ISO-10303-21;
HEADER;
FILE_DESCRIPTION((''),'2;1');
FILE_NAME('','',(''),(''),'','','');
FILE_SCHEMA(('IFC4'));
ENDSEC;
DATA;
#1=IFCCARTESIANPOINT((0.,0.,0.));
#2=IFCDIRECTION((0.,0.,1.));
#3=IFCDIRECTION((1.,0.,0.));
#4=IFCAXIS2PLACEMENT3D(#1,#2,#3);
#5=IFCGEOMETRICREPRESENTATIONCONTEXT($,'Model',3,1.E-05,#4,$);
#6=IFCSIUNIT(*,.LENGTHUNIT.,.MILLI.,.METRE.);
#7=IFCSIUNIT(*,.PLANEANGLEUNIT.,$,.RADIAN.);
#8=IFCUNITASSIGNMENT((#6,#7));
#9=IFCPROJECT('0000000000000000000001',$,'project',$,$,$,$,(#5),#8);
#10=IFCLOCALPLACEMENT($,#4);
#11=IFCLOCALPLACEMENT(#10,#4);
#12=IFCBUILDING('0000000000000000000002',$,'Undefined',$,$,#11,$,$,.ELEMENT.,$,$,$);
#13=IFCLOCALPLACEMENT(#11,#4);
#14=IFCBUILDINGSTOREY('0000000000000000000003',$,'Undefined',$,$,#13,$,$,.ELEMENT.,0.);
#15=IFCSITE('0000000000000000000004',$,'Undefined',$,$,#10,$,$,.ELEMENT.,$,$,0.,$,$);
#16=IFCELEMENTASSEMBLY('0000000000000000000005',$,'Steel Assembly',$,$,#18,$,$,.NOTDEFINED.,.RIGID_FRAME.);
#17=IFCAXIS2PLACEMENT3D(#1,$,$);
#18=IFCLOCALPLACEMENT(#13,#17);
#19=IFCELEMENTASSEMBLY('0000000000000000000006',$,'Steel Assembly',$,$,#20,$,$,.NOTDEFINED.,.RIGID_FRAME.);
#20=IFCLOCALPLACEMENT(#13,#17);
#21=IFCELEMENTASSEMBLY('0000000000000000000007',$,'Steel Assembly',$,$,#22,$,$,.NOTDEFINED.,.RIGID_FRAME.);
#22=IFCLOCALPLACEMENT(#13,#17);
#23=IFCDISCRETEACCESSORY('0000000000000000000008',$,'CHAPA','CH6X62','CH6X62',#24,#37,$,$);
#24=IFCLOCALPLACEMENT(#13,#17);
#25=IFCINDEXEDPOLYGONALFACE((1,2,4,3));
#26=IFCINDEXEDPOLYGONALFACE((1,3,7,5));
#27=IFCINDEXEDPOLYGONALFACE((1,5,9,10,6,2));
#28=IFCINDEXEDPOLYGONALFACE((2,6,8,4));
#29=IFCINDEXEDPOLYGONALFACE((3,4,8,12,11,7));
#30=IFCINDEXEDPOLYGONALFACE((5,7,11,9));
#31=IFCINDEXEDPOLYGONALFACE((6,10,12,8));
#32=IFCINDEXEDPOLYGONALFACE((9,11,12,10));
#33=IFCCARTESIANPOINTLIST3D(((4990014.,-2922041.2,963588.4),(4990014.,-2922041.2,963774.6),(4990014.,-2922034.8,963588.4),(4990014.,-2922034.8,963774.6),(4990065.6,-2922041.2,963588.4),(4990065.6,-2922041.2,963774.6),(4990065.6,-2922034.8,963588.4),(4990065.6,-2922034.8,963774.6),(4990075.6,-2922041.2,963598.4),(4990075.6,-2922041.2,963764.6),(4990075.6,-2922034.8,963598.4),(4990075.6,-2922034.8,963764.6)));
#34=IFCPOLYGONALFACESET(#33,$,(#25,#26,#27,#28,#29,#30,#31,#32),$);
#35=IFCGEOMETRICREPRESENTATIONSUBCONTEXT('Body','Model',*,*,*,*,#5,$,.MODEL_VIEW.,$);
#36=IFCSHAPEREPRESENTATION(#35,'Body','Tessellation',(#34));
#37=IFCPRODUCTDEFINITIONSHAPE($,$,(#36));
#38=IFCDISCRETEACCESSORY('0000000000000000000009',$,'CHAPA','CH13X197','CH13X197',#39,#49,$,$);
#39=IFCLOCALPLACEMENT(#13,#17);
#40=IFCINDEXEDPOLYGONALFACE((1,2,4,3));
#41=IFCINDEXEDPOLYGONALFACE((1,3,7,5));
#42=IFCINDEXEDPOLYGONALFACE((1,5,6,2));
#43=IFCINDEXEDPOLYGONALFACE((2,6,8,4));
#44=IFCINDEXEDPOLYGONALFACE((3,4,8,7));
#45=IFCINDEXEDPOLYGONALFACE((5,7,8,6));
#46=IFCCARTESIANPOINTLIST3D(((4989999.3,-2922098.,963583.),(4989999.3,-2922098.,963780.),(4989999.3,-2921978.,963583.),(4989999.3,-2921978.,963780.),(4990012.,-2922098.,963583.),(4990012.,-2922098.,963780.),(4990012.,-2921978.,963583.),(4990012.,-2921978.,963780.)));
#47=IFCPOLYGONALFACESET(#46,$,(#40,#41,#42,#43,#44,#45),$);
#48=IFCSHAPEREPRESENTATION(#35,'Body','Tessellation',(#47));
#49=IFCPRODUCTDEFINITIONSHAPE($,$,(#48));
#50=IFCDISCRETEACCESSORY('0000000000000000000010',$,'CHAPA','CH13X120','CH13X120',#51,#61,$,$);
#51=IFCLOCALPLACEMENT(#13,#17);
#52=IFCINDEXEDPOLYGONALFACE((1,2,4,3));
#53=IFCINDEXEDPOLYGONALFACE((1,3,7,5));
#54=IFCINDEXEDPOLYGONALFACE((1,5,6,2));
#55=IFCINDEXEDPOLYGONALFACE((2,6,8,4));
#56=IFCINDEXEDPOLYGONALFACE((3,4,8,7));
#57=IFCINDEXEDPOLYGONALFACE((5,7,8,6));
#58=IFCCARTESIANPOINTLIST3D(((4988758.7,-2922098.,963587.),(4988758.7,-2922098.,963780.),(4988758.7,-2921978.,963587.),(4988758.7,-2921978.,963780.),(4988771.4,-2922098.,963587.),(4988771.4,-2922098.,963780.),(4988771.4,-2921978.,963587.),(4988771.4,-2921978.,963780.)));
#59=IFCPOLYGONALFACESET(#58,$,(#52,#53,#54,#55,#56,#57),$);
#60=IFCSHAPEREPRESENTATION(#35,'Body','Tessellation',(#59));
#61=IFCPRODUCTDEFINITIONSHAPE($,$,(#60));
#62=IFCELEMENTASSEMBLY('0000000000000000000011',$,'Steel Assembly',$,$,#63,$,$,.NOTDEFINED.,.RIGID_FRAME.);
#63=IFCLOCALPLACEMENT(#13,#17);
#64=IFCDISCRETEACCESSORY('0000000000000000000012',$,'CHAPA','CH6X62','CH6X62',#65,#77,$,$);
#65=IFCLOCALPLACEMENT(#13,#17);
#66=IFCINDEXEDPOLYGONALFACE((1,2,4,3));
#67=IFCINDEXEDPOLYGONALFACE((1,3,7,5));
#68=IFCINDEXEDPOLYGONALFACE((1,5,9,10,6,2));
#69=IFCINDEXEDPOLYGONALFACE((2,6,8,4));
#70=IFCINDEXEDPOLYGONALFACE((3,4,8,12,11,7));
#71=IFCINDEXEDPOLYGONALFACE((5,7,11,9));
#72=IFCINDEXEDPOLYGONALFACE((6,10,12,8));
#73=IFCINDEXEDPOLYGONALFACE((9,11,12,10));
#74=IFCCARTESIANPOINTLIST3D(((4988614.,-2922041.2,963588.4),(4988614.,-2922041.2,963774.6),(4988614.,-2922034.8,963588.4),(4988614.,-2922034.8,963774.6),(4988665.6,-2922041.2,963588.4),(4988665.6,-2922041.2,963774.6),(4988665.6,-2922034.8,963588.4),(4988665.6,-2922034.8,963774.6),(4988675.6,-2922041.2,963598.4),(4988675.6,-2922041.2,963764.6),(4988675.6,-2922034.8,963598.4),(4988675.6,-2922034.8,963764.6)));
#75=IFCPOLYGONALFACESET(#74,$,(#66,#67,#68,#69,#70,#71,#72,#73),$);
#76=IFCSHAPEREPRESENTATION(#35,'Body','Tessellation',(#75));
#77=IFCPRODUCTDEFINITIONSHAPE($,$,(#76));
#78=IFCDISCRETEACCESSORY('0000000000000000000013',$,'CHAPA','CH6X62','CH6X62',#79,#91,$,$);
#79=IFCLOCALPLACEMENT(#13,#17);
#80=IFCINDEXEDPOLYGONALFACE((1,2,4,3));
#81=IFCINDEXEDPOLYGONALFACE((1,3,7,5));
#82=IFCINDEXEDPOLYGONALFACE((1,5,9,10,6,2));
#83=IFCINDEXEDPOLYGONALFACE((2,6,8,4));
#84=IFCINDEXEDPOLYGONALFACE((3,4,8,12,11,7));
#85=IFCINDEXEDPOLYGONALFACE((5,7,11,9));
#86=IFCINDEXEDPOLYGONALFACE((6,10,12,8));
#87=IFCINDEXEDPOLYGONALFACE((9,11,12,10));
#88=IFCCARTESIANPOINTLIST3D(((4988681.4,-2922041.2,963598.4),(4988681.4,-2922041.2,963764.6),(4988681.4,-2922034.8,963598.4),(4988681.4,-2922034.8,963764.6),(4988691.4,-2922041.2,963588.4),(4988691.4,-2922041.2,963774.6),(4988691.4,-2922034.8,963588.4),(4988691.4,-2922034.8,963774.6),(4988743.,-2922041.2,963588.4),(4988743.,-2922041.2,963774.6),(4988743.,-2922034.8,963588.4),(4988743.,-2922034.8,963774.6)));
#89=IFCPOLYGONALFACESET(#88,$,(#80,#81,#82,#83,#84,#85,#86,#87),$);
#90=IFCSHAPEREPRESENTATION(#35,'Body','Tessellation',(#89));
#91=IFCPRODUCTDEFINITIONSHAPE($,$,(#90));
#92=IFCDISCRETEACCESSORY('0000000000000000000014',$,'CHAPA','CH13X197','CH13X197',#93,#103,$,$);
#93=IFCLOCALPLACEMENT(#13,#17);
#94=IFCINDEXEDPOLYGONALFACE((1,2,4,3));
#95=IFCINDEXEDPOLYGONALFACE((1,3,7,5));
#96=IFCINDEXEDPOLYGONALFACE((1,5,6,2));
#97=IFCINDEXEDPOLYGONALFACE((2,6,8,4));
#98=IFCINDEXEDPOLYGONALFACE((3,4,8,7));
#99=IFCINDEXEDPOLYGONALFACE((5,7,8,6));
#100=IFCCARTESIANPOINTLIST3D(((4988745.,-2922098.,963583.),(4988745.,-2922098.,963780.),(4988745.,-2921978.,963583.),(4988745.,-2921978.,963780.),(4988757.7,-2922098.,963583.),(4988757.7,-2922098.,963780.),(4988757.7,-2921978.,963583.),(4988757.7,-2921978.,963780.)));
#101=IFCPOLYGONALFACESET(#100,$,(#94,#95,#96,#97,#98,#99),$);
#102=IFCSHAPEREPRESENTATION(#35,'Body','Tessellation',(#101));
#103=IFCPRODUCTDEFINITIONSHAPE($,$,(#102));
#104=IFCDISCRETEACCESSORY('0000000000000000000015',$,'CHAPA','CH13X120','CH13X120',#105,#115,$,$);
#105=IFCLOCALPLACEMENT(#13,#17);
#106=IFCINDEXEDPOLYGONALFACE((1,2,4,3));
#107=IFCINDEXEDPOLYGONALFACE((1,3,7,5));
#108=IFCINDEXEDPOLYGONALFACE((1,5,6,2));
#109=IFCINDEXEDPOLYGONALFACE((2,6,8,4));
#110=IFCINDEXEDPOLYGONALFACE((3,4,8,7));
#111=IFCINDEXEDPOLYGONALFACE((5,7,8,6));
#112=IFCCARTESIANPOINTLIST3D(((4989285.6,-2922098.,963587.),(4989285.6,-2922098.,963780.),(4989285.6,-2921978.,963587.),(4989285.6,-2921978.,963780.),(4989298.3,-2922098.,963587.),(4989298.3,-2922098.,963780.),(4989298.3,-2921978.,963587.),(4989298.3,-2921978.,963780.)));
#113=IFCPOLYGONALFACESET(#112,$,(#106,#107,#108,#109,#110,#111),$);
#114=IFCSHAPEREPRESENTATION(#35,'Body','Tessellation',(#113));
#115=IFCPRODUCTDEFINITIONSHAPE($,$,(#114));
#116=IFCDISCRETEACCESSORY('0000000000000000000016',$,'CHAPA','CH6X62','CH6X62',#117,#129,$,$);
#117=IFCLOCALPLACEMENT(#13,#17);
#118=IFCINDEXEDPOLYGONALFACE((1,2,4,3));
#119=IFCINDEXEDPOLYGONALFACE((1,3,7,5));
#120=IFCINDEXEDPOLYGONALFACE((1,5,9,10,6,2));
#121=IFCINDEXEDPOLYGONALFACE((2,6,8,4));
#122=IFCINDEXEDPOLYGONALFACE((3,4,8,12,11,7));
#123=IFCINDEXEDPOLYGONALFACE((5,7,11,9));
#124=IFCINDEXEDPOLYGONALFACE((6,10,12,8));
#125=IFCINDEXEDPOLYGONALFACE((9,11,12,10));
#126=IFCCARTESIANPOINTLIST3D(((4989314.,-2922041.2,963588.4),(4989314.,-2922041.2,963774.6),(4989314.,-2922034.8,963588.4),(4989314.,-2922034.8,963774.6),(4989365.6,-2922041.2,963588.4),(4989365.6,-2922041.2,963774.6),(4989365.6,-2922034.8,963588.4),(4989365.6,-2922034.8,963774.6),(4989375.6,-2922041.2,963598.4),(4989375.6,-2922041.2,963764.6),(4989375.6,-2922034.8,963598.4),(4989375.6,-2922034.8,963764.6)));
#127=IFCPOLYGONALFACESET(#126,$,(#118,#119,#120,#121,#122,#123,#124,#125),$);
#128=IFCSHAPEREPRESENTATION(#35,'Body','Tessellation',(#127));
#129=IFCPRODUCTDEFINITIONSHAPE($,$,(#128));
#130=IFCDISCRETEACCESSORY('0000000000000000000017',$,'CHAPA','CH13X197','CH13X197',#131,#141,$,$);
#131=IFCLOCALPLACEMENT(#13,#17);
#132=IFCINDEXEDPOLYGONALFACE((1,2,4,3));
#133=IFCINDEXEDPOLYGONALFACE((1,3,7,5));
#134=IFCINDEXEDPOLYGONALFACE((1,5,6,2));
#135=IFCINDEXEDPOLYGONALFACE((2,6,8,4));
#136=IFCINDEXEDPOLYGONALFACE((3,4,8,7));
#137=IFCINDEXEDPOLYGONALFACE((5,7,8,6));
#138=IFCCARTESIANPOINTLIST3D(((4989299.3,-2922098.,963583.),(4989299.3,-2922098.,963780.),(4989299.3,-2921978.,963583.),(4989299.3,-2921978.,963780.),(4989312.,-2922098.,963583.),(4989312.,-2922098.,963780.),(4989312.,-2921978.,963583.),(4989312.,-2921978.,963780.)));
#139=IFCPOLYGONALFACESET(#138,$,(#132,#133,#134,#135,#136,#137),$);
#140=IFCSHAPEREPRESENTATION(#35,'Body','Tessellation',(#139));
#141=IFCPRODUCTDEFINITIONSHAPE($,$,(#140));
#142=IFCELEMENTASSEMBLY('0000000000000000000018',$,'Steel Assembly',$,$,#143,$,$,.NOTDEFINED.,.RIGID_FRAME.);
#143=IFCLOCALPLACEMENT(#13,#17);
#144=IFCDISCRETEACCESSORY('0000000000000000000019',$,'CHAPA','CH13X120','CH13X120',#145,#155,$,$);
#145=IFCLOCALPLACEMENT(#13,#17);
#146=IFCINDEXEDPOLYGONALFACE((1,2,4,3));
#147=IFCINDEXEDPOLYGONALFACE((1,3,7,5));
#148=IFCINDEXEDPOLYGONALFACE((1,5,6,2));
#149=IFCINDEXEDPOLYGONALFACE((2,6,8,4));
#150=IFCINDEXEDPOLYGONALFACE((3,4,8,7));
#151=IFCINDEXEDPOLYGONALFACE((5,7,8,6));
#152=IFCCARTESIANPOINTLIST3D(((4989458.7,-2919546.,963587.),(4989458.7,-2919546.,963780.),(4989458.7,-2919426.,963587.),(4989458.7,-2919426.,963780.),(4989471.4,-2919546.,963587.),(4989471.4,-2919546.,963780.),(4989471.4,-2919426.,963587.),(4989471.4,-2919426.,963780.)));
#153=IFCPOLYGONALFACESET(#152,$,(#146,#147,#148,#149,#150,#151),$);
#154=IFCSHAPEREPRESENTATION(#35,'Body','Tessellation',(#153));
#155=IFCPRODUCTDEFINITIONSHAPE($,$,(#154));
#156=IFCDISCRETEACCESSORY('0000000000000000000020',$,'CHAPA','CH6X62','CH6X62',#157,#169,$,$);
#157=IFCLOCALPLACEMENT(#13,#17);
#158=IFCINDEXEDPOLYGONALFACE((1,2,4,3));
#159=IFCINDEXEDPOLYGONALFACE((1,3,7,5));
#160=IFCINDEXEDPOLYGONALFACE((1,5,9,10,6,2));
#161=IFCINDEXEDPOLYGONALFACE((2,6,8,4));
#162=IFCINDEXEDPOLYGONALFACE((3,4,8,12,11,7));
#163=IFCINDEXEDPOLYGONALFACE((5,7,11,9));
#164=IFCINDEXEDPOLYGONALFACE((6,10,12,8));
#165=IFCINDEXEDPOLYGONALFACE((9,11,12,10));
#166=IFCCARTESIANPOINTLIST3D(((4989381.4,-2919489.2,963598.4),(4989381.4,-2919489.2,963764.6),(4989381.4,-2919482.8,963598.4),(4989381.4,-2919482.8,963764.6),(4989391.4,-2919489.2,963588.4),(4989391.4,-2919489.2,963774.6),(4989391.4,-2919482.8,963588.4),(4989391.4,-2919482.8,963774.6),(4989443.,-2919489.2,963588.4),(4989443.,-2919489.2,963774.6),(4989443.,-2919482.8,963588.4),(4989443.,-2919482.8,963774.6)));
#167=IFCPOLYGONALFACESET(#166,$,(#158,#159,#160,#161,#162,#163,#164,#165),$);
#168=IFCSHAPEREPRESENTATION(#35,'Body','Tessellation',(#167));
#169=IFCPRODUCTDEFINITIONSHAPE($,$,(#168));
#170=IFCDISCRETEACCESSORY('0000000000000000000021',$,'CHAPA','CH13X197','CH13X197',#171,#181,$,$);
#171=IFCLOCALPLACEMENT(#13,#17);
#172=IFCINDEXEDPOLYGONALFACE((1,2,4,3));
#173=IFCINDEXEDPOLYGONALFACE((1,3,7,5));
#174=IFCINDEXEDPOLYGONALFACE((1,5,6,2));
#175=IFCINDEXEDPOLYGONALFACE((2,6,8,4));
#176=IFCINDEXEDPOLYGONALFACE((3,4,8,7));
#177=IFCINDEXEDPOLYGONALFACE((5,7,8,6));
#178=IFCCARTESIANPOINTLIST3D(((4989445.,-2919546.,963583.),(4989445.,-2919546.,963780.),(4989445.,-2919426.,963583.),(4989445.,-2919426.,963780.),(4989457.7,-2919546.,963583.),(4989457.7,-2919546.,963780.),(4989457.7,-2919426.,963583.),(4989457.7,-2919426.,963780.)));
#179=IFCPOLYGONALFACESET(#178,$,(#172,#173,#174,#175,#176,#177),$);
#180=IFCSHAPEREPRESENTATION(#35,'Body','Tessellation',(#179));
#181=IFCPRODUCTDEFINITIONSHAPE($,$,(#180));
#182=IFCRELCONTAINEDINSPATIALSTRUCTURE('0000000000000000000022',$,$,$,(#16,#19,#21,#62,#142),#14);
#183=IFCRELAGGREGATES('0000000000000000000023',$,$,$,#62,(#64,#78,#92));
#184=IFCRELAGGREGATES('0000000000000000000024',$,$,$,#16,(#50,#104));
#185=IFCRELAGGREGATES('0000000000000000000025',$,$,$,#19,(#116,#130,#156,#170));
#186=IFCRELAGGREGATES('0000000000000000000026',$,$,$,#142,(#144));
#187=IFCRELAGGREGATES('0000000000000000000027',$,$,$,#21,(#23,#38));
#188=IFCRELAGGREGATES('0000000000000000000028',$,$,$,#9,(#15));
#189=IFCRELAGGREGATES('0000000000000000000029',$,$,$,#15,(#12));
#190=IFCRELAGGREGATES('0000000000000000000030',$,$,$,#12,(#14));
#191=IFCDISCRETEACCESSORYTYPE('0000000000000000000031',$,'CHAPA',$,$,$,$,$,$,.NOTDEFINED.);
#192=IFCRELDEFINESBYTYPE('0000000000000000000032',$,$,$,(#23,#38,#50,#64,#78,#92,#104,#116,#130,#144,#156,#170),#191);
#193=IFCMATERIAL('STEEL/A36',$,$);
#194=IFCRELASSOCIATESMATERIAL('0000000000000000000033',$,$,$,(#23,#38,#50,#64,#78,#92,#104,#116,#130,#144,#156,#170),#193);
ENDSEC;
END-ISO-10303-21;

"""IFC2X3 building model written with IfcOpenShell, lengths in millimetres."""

from ifc_helpers import new_model, si_unit, frame, origin_with_axes, place, context, subcontext, project, spatial, polyline, outline, extrude, material, type_object, element, aggregate, save


model = new_model("IFC2X3")

# Units and contexts
model_context = context("Model", 3, precision=1e-05, world=origin_with_axes())
body_context = subcontext(model_context, "Body", "Model", "MODEL_VIEW")
ifc_project = project(units=[si_unit("LENGTHUNIT", "METRE", prefix="MILLI"), si_unit("PLANEANGLEUNIT", "RADIAN")], contexts=[model_context])

# Site, building, storey
site_placement = place(None, origin_with_axes())
site = spatial("IfcSite", under=ifc_project, at=site_placement, Name="Undefined", CompositionType="ELEMENT", RefElevation=0.0)
building_placement = place(site_placement, origin_with_axes())
building = spatial("IfcBuilding", under=site, at=building_placement, Name="Undefined", CompositionType="ELEMENT")
storey_placement = place(building_placement, origin_with_axes())
storey = spatial("IfcBuildingStorey", under=building, at=storey_placement, Name="Undefined", CompositionType="ELEMENT", Elevation=0.0)

# Element assembly
assembly_1_placement = place(storey_placement, origin_with_axes())
assembly_1 = element("IfcElementAssembly", 1, at=assembly_1_placement, inside=storey, Name="Steel Assembly", AssemblyPlace="NOTDEFINED", PredefinedType="RIGID_FRAME")

# Shared definitions
ifc_material_1 = material(Name="STEEL/A36")
discrete_accessory_type_1 = type_object("IfcDiscreteAccessoryType", Name="CHAPA")

# Element assembly
assembly_2_placement = place(storey_placement, origin_with_axes())
assembly_2 = element("IfcElementAssembly", 2, at=assembly_2_placement, inside=storey, Name="Steel Assembly", AssemblyPlace="NOTDEFINED", PredefinedType="RIGID_FRAME")

# Element assembly, discrete accessories
assembly_3_placement = place(storey_placement, origin_with_axes())
assembly_3 = element("IfcElementAssembly", 3, at=assembly_3_placement, inside=storey, Name="Steel Assembly", AssemblyPlace="NOTDEFINED", PredefinedType="RIGID_FRAME")
discrete_accessory_1_placement = place(assembly_3_placement, frame((4990075.6, -2922038.0, 963774.6), z_axis=(0.0, -1.0, 0.0), x_axis=(-1.0, 0.0, 0.0)))
discrete_accessory_1 = element("IfcDiscreteAccessory", 4, at=discrete_accessory_1_placement, type_object=discrete_accessory_type_1, material=ifc_material_1, Name="CHAPA", Description="CH6X62", ObjectType="CH6X62", context=body_context, shape_type="SweptSolid", body=[
    extrude(outline(polyline([(0.0, 10.0), (10.0, 0.0), (61.6, 0.0), (61.6, 186.2), (10.0, 186.2), (0.0, 176.2), (0.0, 10.0)])), frame((0.0, 0.0, -3.2), z_axis=(0.0, 0.0, 1.0), x_axis=(1.0, 0.0, 0.0)), (0.0, 0.0, 1.0), 6.4),
])
discrete_accessory_2_placement = place(assembly_3_placement, frame((4990005.6, -2922038.0, 963780.0), z_axis=(-1.0, 0.0, 0.0), x_axis=(0.0, 0.0, -1.0)))
discrete_accessory_2 = element("IfcDiscreteAccessory", 5, at=discrete_accessory_2_placement, type_object=discrete_accessory_type_1, material=ifc_material_1, Name="CHAPA", Description="CH13X197", ObjectType="CH13X197", context=body_context, shape_type="SweptSolid", body=[
    extrude(outline(polyline([(197.0, 60.0), (197.0, -60.0), (0.0, -60.0), (0.0, 60.0), (197.0, 60.0)])), frame((0.0, 0.0, -6.3), z_axis=(0.0, 0.0, 1.0), x_axis=(1.0, 0.0, 0.0)), (0.0, 0.0, 1.0), 12.7),
])

# Discrete accessory
discrete_accessory_3_placement = place(assembly_1_placement, frame((4988765.0, -2922038.0, 963780.0), z_axis=(1.0, 0.0, 0.0), x_axis=(0.0, 0.0, -1.0)))
discrete_accessory_3 = element("IfcDiscreteAccessory", 6, at=discrete_accessory_3_placement, type_object=discrete_accessory_type_1, material=ifc_material_1, Name="CHAPA", Description="CH13X120", ObjectType="CH13X120", context=body_context, shape_type="SweptSolid", body=[
    extrude(outline(polyline([(193.0, -60.0), (0.0, -60.0), (0.0, 60.0), (193.0, 60.0), (193.0, -60.0)])), frame((0.0, 0.0, -6.3), z_axis=(0.0, 0.0, 1.0), x_axis=(1.0, 0.0, 0.0)), (0.0, 0.0, 1.0), 12.7),
])

# Element assembly, discrete accessories
assembly_4_placement = place(storey_placement, origin_with_axes())
assembly_4 = element("IfcElementAssembly", 7, at=assembly_4_placement, inside=storey, Name="Steel Assembly", AssemblyPlace="NOTDEFINED", PredefinedType="RIGID_FRAME")
discrete_accessory_4_placement = place(assembly_4_placement, frame((4988675.6, -2922038.0, 963774.6), z_axis=(0.0, -1.0, 0.0), x_axis=(-1.0, 0.0, 0.0)))
discrete_accessory_4 = element("IfcDiscreteAccessory", 8, at=discrete_accessory_4_placement, type_object=discrete_accessory_type_1, material=ifc_material_1, Name="CHAPA", Description="CH6X62", ObjectType="CH6X62", context=body_context, shape_type="SweptSolid", body=[
    extrude(outline(polyline([(0.0, 10.0), (10.0, 0.0), (61.6, 0.0), (61.6, 186.2), (10.0, 186.2), (0.0, 176.2), (0.0, 10.0)])), frame((0.0, 0.0, -3.2), z_axis=(0.0, 0.0, 1.0), x_axis=(1.0, 0.0, 0.0)), (0.0, 0.0, 1.0), 6.4),
])
discrete_accessory_5_placement = place(assembly_4_placement, frame((4988681.4, -2922038.0, 963774.6), z_axis=(0.0, 1.0, 0.0), x_axis=(1.0, 0.0, 0.0)))
discrete_accessory_5 = element("IfcDiscreteAccessory", 9, at=discrete_accessory_5_placement, type_object=discrete_accessory_type_1, material=ifc_material_1, Name="CHAPA", Description="CH6X62", ObjectType="CH6X62", context=body_context, shape_type="SweptSolid", body=[
    extrude(outline(polyline([(0.0, 10.0), (10.0, 0.0), (61.6, 0.0), (61.6, 186.2), (10.0, 186.2), (0.0, 176.2), (0.0, 10.0)])), frame((0.0, 0.0, -3.2), z_axis=(0.0, 0.0, 1.0), x_axis=(1.0, 0.0, 0.0)), (0.0, 0.0, 1.0), 6.4),
])
discrete_accessory_6_placement = place(assembly_4_placement, frame((4988751.3, -2922038.0, 963780.0), z_axis=(1.0, 0.0, 0.0), x_axis=(0.0, 0.0, -1.0)))
discrete_accessory_6 = element("IfcDiscreteAccessory", 10, at=discrete_accessory_6_placement, type_object=discrete_accessory_type_1, material=ifc_material_1, Name="CHAPA", Description="CH13X197", ObjectType="CH13X197", context=body_context, shape_type="SweptSolid", body=[
    extrude(outline(polyline([(197.0, -60.0), (0.0, -60.0), (0.0, 60.0), (197.0, 60.0), (197.0, -60.0)])), frame((0.0, 0.0, -6.3), z_axis=(0.0, 0.0, 1.0), x_axis=(1.0, 0.0, 0.0)), (0.0, 0.0, 1.0), 12.7),
])
aggregate(assembly_4, [discrete_accessory_4, discrete_accessory_5, discrete_accessory_6])

# Discrete accessories
discrete_accessory_7_placement = place(assembly_1_placement, frame((4989291.9, -2922038.0, 963780.0), z_axis=(-1.0, 0.0, 0.0), x_axis=(0.0, 0.0, -1.0)))
discrete_accessory_7 = element("IfcDiscreteAccessory", 11, at=discrete_accessory_7_placement, type_object=discrete_accessory_type_1, material=ifc_material_1, Name="CHAPA", Description="CH13X120", ObjectType="CH13X120", context=body_context, shape_type="SweptSolid", body=[
    extrude(outline(polyline([(193.0, 60.0), (193.0, -60.0), (0.0, -60.0), (0.0, 60.0), (193.0, 60.0)])), frame((0.0, 0.0, -6.3), z_axis=(0.0, 0.0, 1.0), x_axis=(1.0, 0.0, 0.0)), (0.0, 0.0, 1.0), 12.7),
])
aggregate(assembly_1, [discrete_accessory_3, discrete_accessory_7])
discrete_accessory_8_placement = place(assembly_2_placement, frame((4989375.6, -2922038.0, 963774.6), z_axis=(0.0, -1.0, 0.0), x_axis=(-1.0, 0.0, 0.0)))
discrete_accessory_8 = element("IfcDiscreteAccessory", 12, at=discrete_accessory_8_placement, type_object=discrete_accessory_type_1, material=ifc_material_1, Name="CHAPA", Description="CH6X62", ObjectType="CH6X62", context=body_context, shape_type="SweptSolid", body=[
    extrude(outline(polyline([(0.0, 10.0), (10.0, 0.0), (61.6, 0.0), (61.6, 186.2), (10.0, 186.2), (0.0, 176.2), (0.0, 10.0)])), frame((0.0, 0.0, -3.2), z_axis=(0.0, 0.0, 1.0), x_axis=(1.0, 0.0, 0.0)), (0.0, 0.0, 1.0), 6.4),
])
discrete_accessory_9_placement = place(assembly_2_placement, frame((4989305.6, -2922038.0, 963780.0), z_axis=(-1.0, 0.0, 0.0), x_axis=(0.0, 0.0, -1.0)))
discrete_accessory_9 = element("IfcDiscreteAccessory", 13, at=discrete_accessory_9_placement, type_object=discrete_accessory_type_1, material=ifc_material_1, Name="CHAPA", Description="CH13X197", ObjectType="CH13X197", context=body_context, shape_type="SweptSolid", body=[
    extrude(outline(polyline([(197.0, 60.0), (197.0, -60.0), (0.0, -60.0), (0.0, 60.0), (197.0, 60.0)])), frame((0.0, 0.0, -6.3), z_axis=(0.0, 0.0, 1.0), x_axis=(1.0, 0.0, 0.0)), (0.0, 0.0, 1.0), 12.7),
])

# Element assembly, discrete accessory
assembly_5_placement = place(storey_placement, origin_with_axes())
assembly_5 = element("IfcElementAssembly", 14, at=assembly_5_placement, inside=storey, Name="Steel Assembly", AssemblyPlace="NOTDEFINED", PredefinedType="RIGID_FRAME")
discrete_accessory_10_placement = place(assembly_5_placement, frame((4989465.0, -2919486.0, 963780.0), z_axis=(1.0, 0.0, 0.0), x_axis=(0.0, 0.0, -1.0)))
discrete_accessory_10 = element("IfcDiscreteAccessory", 15, at=discrete_accessory_10_placement, type_object=discrete_accessory_type_1, material=ifc_material_1, Name="CHAPA", Description="CH13X120", ObjectType="CH13X120", context=body_context, shape_type="SweptSolid", body=[
    extrude(outline(polyline([(193.0, -60.0), (0.0, -60.0), (0.0, 60.0), (193.0, 60.0), (193.0, -60.0)])), frame((0.0, 0.0, -6.3), z_axis=(0.0, 0.0, 1.0), x_axis=(1.0, 0.0, 0.0)), (0.0, 0.0, 1.0), 12.7),
])

# Discrete accessories
discrete_accessory_11_placement = place(assembly_2_placement, frame((4989381.4, -2919486.0, 963774.6), z_axis=(0.0, 1.0, 0.0), x_axis=(1.0, 0.0, 0.0)))
discrete_accessory_11 = element("IfcDiscreteAccessory", 16, at=discrete_accessory_11_placement, type_object=discrete_accessory_type_1, material=ifc_material_1, Name="CHAPA", Description="CH6X62", ObjectType="CH6X62", context=body_context, shape_type="SweptSolid", body=[
    extrude(outline(polyline([(0.0, 10.0), (10.0, 0.0), (61.6, 0.0), (61.6, 186.2), (10.0, 186.2), (0.0, 176.2), (0.0, 10.0)])), frame((0.0, 0.0, -3.2), z_axis=(0.0, 0.0, 1.0), x_axis=(1.0, 0.0, 0.0)), (0.0, 0.0, 1.0), 6.4),
])
discrete_accessory_12_placement = place(assembly_2_placement, frame((4989451.3, -2919486.0, 963780.0), z_axis=(1.0, 0.0, 0.0), x_axis=(0.0, 0.0, -1.0)))
discrete_accessory_12 = element("IfcDiscreteAccessory", 17, at=discrete_accessory_12_placement, type_object=discrete_accessory_type_1, material=ifc_material_1, Name="CHAPA", Description="CH13X197", ObjectType="CH13X197", context=body_context, shape_type="SweptSolid", body=[
    extrude(outline(polyline([(197.0, -60.0), (0.0, -60.0), (0.0, 60.0), (197.0, 60.0), (197.0, -60.0)])), frame((0.0, 0.0, -6.3), z_axis=(0.0, 0.0, 1.0), x_axis=(1.0, 0.0, 0.0)), (0.0, 0.0, 1.0), 12.7),
])
aggregate(assembly_2, [discrete_accessory_8, discrete_accessory_9, discrete_accessory_11, discrete_accessory_12])
aggregate(assembly_5, [discrete_accessory_10])
aggregate(assembly_3, [discrete_accessory_1, discrete_accessory_2])

save(model, "model.ifc")
